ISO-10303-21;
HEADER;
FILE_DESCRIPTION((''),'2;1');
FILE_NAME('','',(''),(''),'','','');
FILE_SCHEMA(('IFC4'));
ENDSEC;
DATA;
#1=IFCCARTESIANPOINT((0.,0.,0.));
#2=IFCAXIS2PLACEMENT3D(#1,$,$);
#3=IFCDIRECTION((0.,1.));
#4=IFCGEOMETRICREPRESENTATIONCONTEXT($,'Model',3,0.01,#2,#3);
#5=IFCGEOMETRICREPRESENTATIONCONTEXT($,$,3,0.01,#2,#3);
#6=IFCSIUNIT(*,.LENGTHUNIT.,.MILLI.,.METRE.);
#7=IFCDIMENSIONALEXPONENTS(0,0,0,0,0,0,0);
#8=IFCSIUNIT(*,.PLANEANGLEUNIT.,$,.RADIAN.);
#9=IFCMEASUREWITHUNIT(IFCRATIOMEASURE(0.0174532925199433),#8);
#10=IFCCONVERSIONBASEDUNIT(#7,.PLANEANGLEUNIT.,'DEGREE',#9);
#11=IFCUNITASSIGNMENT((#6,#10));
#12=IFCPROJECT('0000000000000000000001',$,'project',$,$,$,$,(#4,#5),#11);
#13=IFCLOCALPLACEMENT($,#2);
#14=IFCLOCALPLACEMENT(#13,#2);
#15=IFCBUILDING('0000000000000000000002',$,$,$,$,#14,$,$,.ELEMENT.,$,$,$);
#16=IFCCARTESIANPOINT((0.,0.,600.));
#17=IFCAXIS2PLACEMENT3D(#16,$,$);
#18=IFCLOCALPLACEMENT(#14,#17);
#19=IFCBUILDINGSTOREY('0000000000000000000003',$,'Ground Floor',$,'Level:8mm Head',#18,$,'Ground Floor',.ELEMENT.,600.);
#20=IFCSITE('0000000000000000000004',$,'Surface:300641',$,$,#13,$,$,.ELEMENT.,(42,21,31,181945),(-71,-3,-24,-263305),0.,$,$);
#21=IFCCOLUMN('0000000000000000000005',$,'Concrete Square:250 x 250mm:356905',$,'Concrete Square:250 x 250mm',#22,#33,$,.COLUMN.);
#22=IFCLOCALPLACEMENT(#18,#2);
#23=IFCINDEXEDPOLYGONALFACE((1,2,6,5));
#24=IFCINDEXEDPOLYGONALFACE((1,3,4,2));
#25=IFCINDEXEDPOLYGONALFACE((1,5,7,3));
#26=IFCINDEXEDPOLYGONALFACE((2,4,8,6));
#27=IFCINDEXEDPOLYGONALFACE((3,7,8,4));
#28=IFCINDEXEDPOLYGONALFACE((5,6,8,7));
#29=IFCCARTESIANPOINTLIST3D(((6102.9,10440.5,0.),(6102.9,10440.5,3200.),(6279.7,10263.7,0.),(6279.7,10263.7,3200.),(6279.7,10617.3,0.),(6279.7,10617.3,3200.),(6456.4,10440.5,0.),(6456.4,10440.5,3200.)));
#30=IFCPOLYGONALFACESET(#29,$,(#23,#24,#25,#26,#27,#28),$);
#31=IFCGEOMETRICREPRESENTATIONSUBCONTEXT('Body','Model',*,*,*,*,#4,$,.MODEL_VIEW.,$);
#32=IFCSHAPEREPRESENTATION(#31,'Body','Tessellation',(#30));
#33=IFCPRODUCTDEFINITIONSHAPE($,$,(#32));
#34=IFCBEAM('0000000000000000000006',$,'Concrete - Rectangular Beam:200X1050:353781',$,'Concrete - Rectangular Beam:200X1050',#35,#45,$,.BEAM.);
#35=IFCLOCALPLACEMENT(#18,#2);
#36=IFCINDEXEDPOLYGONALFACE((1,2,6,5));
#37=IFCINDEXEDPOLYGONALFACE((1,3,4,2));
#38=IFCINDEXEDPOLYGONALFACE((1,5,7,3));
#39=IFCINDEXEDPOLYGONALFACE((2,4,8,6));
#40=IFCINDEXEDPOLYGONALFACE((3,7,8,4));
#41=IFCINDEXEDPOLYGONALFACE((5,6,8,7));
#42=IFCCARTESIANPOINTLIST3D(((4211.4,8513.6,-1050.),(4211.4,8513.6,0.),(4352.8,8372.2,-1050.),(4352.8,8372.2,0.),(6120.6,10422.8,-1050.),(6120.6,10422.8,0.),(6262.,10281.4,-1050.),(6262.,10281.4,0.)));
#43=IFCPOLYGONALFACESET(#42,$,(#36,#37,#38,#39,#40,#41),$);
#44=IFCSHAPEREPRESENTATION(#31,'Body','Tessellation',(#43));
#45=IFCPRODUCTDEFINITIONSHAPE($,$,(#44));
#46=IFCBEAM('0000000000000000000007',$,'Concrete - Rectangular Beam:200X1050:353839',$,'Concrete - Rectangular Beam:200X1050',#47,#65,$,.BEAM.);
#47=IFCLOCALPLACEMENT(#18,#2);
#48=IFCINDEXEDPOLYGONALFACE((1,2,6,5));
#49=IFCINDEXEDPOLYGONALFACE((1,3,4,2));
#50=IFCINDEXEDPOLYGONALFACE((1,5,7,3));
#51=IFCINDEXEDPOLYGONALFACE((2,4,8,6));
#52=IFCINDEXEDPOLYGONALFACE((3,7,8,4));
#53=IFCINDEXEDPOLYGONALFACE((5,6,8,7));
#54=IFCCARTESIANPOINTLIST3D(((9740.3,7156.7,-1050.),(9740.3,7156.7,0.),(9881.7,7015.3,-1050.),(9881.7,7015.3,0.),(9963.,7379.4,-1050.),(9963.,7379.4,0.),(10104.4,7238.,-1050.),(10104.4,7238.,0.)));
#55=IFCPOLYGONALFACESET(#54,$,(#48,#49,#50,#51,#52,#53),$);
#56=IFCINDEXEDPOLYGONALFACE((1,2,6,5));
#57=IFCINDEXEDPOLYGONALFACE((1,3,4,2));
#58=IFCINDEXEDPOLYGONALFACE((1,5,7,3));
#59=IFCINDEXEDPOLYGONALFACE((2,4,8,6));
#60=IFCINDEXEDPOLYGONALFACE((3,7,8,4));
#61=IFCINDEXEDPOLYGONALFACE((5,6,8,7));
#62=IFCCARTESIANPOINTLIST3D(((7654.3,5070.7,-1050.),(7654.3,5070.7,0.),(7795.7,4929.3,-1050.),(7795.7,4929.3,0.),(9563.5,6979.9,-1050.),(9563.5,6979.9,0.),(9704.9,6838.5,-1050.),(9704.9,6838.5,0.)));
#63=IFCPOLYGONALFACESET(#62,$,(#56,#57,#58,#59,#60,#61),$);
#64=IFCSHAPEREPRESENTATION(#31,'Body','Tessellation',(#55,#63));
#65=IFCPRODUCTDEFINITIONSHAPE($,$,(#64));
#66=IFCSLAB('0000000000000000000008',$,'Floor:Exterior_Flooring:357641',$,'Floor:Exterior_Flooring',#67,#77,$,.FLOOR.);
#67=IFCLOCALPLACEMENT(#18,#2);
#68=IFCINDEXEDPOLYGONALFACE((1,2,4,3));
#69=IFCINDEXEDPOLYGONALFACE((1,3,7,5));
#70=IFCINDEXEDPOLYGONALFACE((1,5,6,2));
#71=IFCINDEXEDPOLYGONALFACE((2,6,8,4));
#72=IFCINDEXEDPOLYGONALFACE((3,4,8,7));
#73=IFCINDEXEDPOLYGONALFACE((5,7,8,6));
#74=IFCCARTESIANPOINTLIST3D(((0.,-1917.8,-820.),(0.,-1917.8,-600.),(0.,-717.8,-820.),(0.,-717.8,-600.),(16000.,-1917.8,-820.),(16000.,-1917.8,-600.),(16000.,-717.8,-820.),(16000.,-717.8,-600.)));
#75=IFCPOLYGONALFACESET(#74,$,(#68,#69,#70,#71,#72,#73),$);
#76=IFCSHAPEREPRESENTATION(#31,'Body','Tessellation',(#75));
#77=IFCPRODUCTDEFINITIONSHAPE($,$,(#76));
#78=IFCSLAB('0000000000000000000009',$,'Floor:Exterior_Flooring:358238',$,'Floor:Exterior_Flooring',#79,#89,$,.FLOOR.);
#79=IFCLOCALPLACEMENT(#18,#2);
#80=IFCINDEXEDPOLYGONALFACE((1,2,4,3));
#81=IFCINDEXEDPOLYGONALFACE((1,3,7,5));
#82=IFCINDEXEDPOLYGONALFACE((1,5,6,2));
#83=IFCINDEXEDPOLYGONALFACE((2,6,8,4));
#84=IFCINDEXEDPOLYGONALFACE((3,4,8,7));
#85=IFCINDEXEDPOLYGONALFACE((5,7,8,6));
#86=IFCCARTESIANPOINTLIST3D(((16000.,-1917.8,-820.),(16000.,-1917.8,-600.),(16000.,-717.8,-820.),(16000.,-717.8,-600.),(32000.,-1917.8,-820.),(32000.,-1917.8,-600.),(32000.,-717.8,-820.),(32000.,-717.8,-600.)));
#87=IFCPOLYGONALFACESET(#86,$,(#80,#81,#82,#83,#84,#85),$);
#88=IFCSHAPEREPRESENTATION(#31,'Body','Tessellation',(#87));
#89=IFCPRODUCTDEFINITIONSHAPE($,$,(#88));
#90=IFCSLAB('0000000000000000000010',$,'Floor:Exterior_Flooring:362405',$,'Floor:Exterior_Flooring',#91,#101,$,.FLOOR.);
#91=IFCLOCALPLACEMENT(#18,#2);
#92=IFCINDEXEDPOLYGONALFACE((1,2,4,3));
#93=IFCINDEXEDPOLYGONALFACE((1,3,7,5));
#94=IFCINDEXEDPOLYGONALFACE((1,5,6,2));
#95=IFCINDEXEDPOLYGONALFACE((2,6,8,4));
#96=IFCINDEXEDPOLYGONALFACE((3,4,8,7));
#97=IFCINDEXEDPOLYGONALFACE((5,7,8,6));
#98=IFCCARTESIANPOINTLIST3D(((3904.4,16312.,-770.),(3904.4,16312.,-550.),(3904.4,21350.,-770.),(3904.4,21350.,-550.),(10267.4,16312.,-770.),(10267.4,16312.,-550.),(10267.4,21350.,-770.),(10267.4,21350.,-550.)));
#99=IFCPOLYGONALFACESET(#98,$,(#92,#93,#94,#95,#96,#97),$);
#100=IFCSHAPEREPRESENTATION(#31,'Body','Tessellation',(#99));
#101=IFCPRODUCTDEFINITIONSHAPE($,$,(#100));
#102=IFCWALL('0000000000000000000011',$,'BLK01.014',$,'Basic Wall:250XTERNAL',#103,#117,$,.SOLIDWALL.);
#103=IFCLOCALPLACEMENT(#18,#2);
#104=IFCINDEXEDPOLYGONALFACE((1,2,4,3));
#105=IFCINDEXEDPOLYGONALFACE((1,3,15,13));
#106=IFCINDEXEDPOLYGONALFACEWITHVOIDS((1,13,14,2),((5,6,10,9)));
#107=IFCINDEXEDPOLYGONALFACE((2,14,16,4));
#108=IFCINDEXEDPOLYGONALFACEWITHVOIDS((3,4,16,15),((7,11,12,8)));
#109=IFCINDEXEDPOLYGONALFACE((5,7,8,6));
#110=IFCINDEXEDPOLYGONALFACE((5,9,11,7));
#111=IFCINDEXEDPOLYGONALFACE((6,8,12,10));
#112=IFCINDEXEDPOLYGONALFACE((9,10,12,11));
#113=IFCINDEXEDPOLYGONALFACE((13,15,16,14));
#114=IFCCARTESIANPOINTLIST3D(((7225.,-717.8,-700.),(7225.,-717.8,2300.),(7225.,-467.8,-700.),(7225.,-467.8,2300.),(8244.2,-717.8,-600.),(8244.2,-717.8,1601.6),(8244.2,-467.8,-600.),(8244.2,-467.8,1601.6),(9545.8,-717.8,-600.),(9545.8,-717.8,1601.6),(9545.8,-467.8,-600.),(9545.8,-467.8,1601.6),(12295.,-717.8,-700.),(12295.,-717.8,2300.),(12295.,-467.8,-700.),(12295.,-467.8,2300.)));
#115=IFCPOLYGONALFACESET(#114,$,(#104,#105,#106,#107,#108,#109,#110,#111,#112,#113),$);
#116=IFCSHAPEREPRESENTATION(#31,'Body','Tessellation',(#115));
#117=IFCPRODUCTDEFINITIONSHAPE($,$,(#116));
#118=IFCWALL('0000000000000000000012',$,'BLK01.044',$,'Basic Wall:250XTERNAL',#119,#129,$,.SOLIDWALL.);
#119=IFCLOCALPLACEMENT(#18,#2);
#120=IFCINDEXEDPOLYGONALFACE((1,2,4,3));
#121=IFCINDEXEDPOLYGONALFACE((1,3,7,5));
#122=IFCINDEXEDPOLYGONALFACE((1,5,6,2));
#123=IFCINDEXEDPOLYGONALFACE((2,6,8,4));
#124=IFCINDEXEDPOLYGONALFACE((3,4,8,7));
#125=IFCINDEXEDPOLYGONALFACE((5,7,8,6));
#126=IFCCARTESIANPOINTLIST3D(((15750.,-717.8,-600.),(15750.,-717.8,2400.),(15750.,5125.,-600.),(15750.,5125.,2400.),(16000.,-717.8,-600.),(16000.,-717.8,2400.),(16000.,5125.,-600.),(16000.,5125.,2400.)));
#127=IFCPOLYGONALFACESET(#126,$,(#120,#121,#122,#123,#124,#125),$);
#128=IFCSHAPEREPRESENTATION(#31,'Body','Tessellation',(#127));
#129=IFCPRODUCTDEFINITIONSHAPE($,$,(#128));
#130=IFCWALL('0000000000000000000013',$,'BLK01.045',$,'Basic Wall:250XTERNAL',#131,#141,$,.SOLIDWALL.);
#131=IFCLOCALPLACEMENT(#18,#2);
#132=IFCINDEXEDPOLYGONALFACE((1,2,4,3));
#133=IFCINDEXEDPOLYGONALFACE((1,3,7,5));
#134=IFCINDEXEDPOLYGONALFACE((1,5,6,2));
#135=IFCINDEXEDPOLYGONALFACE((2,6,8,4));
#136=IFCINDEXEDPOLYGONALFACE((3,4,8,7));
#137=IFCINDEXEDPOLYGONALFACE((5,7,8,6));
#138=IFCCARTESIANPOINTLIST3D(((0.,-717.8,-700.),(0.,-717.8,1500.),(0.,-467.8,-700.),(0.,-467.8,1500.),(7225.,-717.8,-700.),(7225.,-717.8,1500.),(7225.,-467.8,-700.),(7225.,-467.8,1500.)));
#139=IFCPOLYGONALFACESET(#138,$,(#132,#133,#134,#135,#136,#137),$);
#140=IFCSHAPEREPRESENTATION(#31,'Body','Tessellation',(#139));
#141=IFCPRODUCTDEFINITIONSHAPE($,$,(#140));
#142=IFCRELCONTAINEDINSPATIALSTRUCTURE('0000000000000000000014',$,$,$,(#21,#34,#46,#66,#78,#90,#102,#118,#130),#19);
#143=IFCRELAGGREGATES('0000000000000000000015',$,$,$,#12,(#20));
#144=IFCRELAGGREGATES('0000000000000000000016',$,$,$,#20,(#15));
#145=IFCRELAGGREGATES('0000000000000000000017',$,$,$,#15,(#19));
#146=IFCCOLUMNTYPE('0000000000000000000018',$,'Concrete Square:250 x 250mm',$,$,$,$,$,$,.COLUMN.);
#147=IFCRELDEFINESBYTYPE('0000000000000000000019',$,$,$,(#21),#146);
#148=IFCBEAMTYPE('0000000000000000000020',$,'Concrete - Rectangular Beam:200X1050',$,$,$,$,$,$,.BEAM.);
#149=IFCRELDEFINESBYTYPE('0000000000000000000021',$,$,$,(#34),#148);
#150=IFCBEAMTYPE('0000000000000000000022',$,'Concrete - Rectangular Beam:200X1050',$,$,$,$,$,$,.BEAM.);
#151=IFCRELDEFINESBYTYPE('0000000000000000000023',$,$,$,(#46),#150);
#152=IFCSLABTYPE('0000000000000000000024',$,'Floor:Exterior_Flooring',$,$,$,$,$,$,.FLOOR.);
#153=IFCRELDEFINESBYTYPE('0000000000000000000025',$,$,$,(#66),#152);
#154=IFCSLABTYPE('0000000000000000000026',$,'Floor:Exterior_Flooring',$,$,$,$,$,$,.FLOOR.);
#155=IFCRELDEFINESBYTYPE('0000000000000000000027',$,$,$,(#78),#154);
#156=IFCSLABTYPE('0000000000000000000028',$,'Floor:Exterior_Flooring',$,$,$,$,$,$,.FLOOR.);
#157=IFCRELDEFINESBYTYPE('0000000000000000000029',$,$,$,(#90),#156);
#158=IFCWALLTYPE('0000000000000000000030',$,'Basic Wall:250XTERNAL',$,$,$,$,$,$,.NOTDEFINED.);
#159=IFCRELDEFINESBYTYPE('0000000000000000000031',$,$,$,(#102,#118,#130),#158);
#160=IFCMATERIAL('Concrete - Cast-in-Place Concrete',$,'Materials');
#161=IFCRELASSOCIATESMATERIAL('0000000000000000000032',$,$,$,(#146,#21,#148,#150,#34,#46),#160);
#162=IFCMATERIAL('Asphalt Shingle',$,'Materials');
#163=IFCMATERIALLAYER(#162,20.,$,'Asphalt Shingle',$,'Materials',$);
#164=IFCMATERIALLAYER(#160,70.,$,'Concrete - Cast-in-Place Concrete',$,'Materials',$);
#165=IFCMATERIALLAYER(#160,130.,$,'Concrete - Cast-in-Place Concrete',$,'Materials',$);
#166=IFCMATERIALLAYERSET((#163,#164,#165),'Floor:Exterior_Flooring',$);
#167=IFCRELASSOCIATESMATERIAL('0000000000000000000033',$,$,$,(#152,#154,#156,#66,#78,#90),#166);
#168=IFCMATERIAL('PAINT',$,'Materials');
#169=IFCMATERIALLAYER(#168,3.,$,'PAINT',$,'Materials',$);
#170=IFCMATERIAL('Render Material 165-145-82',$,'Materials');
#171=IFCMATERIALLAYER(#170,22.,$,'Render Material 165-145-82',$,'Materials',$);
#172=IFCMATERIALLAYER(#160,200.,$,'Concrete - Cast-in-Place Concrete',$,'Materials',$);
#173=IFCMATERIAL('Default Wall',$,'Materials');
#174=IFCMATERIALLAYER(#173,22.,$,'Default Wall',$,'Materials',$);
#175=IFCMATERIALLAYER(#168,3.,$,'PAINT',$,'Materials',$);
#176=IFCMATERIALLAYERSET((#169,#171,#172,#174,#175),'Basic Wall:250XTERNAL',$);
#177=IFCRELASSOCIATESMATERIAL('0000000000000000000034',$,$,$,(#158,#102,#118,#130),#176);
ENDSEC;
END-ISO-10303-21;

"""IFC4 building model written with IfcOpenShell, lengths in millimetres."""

from ifc_helpers import new_model, entity, si_unit, converted_unit, direction, frame, frame_2d, origin, origin_2d_with_axis, place, context, subcontext, project, spatial, rectangle, extrude, source, transform, mapped, material, layer, layer_set, layer_usage, material_profile, profile_set, profile_usage, type_object, type_shapes, element, save


model = new_model("IFC4")

# Units and contexts
model_context = context("Model", 3, precision=0.01, world=origin(), true_north=direction((0.0, 1.0)))
context_of_model = context(None, 3, precision=0.01, world=origin(), true_north=direction((0.0, 1.0)))
body_context = subcontext(model_context, "Body", "Model", "MODEL_VIEW")
ifc_project = project(units=[si_unit("LENGTHUNIT", "METRE", prefix="MILLI"), converted_unit("PLANEANGLEUNIT", "DEGREE", entity("IfcRatioMeasure", 0.0174532925199433), si_unit("PLANEANGLEUNIT", "RADIAN"), dimensions=[0, 0, 0, 0, 0, 0, 0])], contexts=[model_context, context_of_model])

# Site, building, storey
site_placement = place(None, origin())
site = spatial("IfcSite", under=ifc_project, at=site_placement, Name="Surface:300641", CompositionType="ELEMENT", RefLatitude=(42, 21, 31, 181945), RefLongitude=(-71, -3, -24, -263305), RefElevation=0.0)
building_placement = place(site_placement, origin())
building = spatial("IfcBuilding", under=site, at=building_placement, CompositionType="ELEMENT")
storey_placement = place(building_placement, frame((0.0, 0.0, 600.0)))
storey = spatial("IfcBuildingStorey", under=building, at=storey_placement, Name="Ground Floor", ObjectType="Level:8mm Head", LongName="Ground Floor", CompositionType="ELEMENT", Elevation=600.0)

# Column
ifc_material_1 = material(Name="Concrete - Cast-in-Place Concrete", Category="Materials")
ifc_material_profile_1 = material_profile(ifc_material_1, rectangle(XDim=250.0, YDim=250.0, at=frame_2d((0.0, 0.0), x_axis=(1.0, 0.0))), Name="250 x 250mm")
ifc_profile_set_1 = profile_set([ifc_material_profile_1], Name="250 x 250mm")
ifc_profile_usage_1 = profile_usage(ifc_profile_set_1)
column_type = type_object("IfcColumnType", Name="Concrete Square:250 x 250mm", PredefinedType="COLUMN", material=ifc_profile_set_1)
shared_shape_1 = source(origin(), body_context, "Body", "SweptSolid", [
    extrude(rectangle(XDim=250.0, YDim=250.0, at=origin_2d_with_axis()), frame((6279.7, 10440.5, 600.0), z_axis=(0.0, 0.0, 1.0), x_axis=(-0.707107, 0.707107, 0.0)), (0.0, 0.0, 1.0), 3200.0),
])
type_shapes(column_type, [shared_shape_1])
column_placement = place(storey_placement, frame((0.0, 0.0, -600.0)))
element("IfcColumn", 1, at=column_placement, inside=storey, type_object=column_type, material=ifc_profile_usage_1, Name="Concrete Square:250 x 250mm:356905", ObjectType="Concrete Square:250 x 250mm", PredefinedType="COLUMN", context=body_context, shape_type="MappedRepresentation", body=[
    mapped(shared_shape_1, transform((0.0, 0.0, 0.0), scale=1.0)),
])

# Beams
ifc_material_profile_2 = material_profile(ifc_material_1, rectangle(XDim=1050.0, YDim=200.0, at=frame_2d((0.0, 0.0), x_axis=(1.0, 0.0))), Name="200X1050")
ifc_profile_set_2 = profile_set([ifc_material_profile_2], Name="200X1050")
ifc_profile_usage_2 = profile_usage(ifc_profile_set_2, cardinal=8)
beam_type_1 = type_object("IfcBeamType", Name="Concrete - Rectangular Beam:200X1050", PredefinedType="BEAM", material=ifc_profile_set_2)
shared_shape_2 = source(origin(), body_context, "Body", "SweptSolid", [
    extrude(rectangle(XDim=1050.0, YDim=200.0, at=frame_2d((0.0, 0.0), x_axis=(1.0, 0.0))), frame((6191.3, 10352.1, 75.0), z_axis=(-0.707107, -0.707107, 0.0), x_axis=(0.0, 0.0, -1.0)), (0.0, 0.0, 1.0), 2700.0),
])
type_shapes(beam_type_1, [shared_shape_2])
beam_1_placement = place(storey_placement, frame((0.0, 0.0, -600.0)))
element("IfcBeam", 2, at=beam_1_placement, inside=storey, type_object=beam_type_1, material=ifc_profile_usage_2, Name="Concrete - Rectangular Beam:200X1050:353781", ObjectType="Concrete - Rectangular Beam:200X1050", PredefinedType="BEAM", context=body_context, shape_type="MappedRepresentation", body=[
    mapped(shared_shape_2, transform((0.0, 0.0, 0.0), scale=1.0)),
])
ifc_profile_usage_3 = profile_usage(ifc_profile_set_2, cardinal=8)
beam_type_2 = type_object("IfcBeamType", Name="Concrete - Rectangular Beam:200X1050", PredefinedType="BEAM", material=ifc_profile_set_2)
shared_shape_3 = source(origin(), body_context, "Body", "SweptSolid", [
    extrude(rectangle(XDim=1050.0, YDim=200.0, at=frame_2d((0.0, 0.0), x_axis=(1.0, 0.0))), frame((9811.0, 7086.0, 75.0), z_axis=(0.707107, 0.707107, 0.0), x_axis=(0.0, 0.0, 1.0)), (0.0, 0.0, 1.0), 315.0),
    extrude(rectangle(XDim=1050.0, YDim=200.0, at=frame_2d((0.0, 0.0), x_axis=(1.0, 0.0))), frame((7725.0, 5000.0, 75.0), z_axis=(0.707107, 0.707107, 0.0), x_axis=(0.0, 0.0, 1.0)), (0.0, 0.0, 1.0), 2700.0),
])
type_shapes(beam_type_2, [shared_shape_3])
beam_2_placement = place(storey_placement, frame((0.0, 0.0, -600.0)))
element("IfcBeam", 3, at=beam_2_placement, inside=storey, type_object=beam_type_2, material=ifc_profile_usage_3, Name="Concrete - Rectangular Beam:200X1050:353839", ObjectType="Concrete - Rectangular Beam:200X1050", PredefinedType="BEAM", context=body_context, shape_type="MappedRepresentation", body=[
    mapped(shared_shape_3, transform((0.0, 0.0, 0.0), scale=1.0)),
])

# Slabs
ifc_material_2 = material(Name="Asphalt Shingle", Category="Materials")
ifc_layer_1 = layer(ifc_material_2, 20.0, Name="Asphalt Shingle", Category="Materials")
ifc_layer_2 = layer(ifc_material_1, 70.0, Name="Concrete - Cast-in-Place Concrete", Category="Materials")
ifc_layer_3 = layer(ifc_material_1, 130.0, Name="Concrete - Cast-in-Place Concrete", Category="Materials")
ifc_layer_set_1 = layer_set([ifc_layer_1, ifc_layer_2, ifc_layer_3], Name="Floor:Exterior_Flooring")
ifc_layer_usage_1 = layer_usage(ifc_layer_set_1, "AXIS3", "POSITIVE", 0.0)
slab_type_1 = type_object("IfcSlabType", Name="Floor:Exterior_Flooring", PredefinedType="FLOOR", material=ifc_layer_set_1)
slab_1_placement = place(storey_placement, origin())
element("IfcSlab", 4, at=slab_1_placement, inside=storey, type_object=slab_type_1, material=ifc_layer_usage_1, Name="Floor:Exterior_Flooring:357641", ObjectType="Floor:Exterior_Flooring", PredefinedType="FLOOR", context=body_context, shape_type="SweptSolid", body=[
    extrude(rectangle(XDim=1200.0, YDim=16000.0, at=origin_2d_with_axis()), frame((8000.0, -1317.8, -600.0), z_axis=(0.0, 0.0, -1.0), x_axis=(0.0, 1.0, 0.0)), (0.0, 0.0, 1.0), 220.0),
])
ifc_layer_usage_2 = layer_usage(ifc_layer_set_1, "AXIS3", "POSITIVE", 0.0)
slab_type_2 = type_object("IfcSlabType", Name="Floor:Exterior_Flooring", PredefinedType="FLOOR", material=ifc_layer_set_1)
slab_2_placement = place(storey_placement, origin())
element("IfcSlab", 5, at=slab_2_placement, inside=storey, type_object=slab_type_2, material=ifc_layer_usage_2, Name="Floor:Exterior_Flooring:358238", ObjectType="Floor:Exterior_Flooring", PredefinedType="FLOOR", context=body_context, shape_type="SweptSolid", body=[
    extrude(rectangle(XDim=1200.0, YDim=16000.0, at=origin_2d_with_axis()), frame((24000.0, -1317.8, -600.0), z_axis=(0.0, 0.0, -1.0), x_axis=(0.0, 1.0, 0.0)), (0.0, 0.0, 1.0), 220.0),
])
ifc_layer_usage_3 = layer_usage(ifc_layer_set_1, "AXIS3", "POSITIVE", 0.0)
slab_type_3 = type_object("IfcSlabType", Name="Floor:Exterior_Flooring", PredefinedType="FLOOR", material=ifc_layer_set_1)
slab_3_placement = place(storey_placement, origin())
element("IfcSlab", 6, at=slab_3_placement, inside=storey, type_object=slab_type_3, material=ifc_layer_usage_3, Name="Floor:Exterior_Flooring:362405", ObjectType="Floor:Exterior_Flooring", PredefinedType="FLOOR", context=body_context, shape_type="SweptSolid", body=[
    extrude(rectangle(XDim=5038.0, YDim=6362.9, at=origin_2d_with_axis()), frame((7085.9, 18831.0, -550.0), z_axis=(0.0, 0.0, -1.0), x_axis=(0.0, 1.0, 0.0)), (0.0, 0.0, 1.0), 220.0),
])

# Wall, opening
ifc_material_3 = material(Name="PAINT", Category="Materials")
ifc_layer_4 = layer(ifc_material_3, 3.0, Name="PAINT", Category="Materials")
ifc_material_4 = material(Name="Render Material 165-145-82", Category="Materials")
ifc_layer_5 = layer(ifc_material_4, 22.0, Name="Render Material 165-145-82", Category="Materials")
ifc_layer_6 = layer(ifc_material_1, 200.0, Name="Concrete - Cast-in-Place Concrete", Category="Materials")
ifc_material_5 = material(Name="Default Wall", Category="Materials")
ifc_layer_7 = layer(ifc_material_5, 22.0, Name="Default Wall", Category="Materials")
ifc_layer_8 = layer(ifc_material_3, 3.0, Name="PAINT", Category="Materials")
ifc_layer_set_2 = layer_set([ifc_layer_4, ifc_layer_5, ifc_layer_6, ifc_layer_7, ifc_layer_8], Name="Basic Wall:250XTERNAL")
ifc_layer_usage_4 = layer_usage(ifc_layer_set_2, "AXIS2", "NEGATIVE", 125.0)
wall_type_1 = type_object("IfcWallType", Name="Basic Wall:250XTERNAL", PredefinedType="NOTDEFINED", material=ifc_layer_set_2)
wall_1_placement = place(storey_placement, frame((12295.0, -592.8, -700.0), z_axis=(0.0, 0.0, 1.0), x_axis=(-1.0, 0.0, 0.0)))
wall_1 = element("IfcWall", 7, at=wall_1_placement, inside=storey, type_object=wall_type_1, material=ifc_layer_usage_4, Name="BLK01.014", ObjectType="Basic Wall:250XTERNAL", PredefinedType="SOLIDWALL", context=body_context, shape_type="SweptSolid", body=[
    extrude(rectangle(XDim=5070.0, YDim=250.0, at=frame_2d((2535.0, 0.0), x_axis=(-1.0, 0.0))), origin(), (0.0, 0.0, 1.0), 3000.0),
])
opening_1_placement = place(wall_1_placement, frame((4050.8, 125.0, 100.0)))
element("IfcOpeningElement", 8, at=opening_1_placement, cuts=wall_1, ObjectType="Opening", PredefinedType="OPENING", context=body_context, shape_type="SweptSolid", body=[
    extrude(rectangle(XDim=2201.6, YDim=1301.6, at=frame_2d((1100.8, 650.8), x_axis=(1.0, 0.0))), frame((0.0, 0.0, 0.0), z_axis=(0.0, -1.0, 0.0), x_axis=(0.0, 0.0, 1.0)), (0.0, 0.0, 1.0), 250.0),
])

# Walls
ifc_layer_usage_5 = layer_usage(ifc_layer_set_2, "AXIS2", "NEGATIVE", 125.0)
wall_2_placement = place(storey_placement, frame((15875.0, -717.8, -600.0), z_axis=(0.0, 0.0, 1.0), x_axis=(0.0, 1.0, 0.0)))
element("IfcWall", 9, at=wall_2_placement, inside=storey, type_object=wall_type_1, material=ifc_layer_usage_5, Name="BLK01.044", ObjectType="Basic Wall:250XTERNAL", PredefinedType="SOLIDWALL", context=body_context, shape_type="SweptSolid", body=[
    extrude(rectangle(XDim=5842.8, YDim=250.0, at=frame_2d((2921.4, 0.0), x_axis=(-1.0, 0.0))), origin(), (0.0, 0.0, 1.0), 3000.0),
])
ifc_layer_usage_6 = layer_usage(ifc_layer_set_2, "AXIS2", "NEGATIVE", 125.0)
wall_3_placement = place(storey_placement, frame((7225.0, -592.8, -700.0), z_axis=(0.0, 0.0, 1.0), x_axis=(-1.0, 0.0, 0.0)))
element("IfcWall", 10, at=wall_3_placement, inside=storey, type_object=wall_type_1, material=ifc_layer_usage_6, Name="BLK01.045", ObjectType="Basic Wall:250XTERNAL", PredefinedType="SOLIDWALL", context=body_context, shape_type="SweptSolid", body=[
    extrude(rectangle(XDim=7225.0, YDim=250.0, at=frame_2d((3612.5, 0.0), x_axis=(-1.0, 0.0))), origin(), (0.0, 0.0, 1.0), 2200.0),
])

save(model, "model.ifc")
